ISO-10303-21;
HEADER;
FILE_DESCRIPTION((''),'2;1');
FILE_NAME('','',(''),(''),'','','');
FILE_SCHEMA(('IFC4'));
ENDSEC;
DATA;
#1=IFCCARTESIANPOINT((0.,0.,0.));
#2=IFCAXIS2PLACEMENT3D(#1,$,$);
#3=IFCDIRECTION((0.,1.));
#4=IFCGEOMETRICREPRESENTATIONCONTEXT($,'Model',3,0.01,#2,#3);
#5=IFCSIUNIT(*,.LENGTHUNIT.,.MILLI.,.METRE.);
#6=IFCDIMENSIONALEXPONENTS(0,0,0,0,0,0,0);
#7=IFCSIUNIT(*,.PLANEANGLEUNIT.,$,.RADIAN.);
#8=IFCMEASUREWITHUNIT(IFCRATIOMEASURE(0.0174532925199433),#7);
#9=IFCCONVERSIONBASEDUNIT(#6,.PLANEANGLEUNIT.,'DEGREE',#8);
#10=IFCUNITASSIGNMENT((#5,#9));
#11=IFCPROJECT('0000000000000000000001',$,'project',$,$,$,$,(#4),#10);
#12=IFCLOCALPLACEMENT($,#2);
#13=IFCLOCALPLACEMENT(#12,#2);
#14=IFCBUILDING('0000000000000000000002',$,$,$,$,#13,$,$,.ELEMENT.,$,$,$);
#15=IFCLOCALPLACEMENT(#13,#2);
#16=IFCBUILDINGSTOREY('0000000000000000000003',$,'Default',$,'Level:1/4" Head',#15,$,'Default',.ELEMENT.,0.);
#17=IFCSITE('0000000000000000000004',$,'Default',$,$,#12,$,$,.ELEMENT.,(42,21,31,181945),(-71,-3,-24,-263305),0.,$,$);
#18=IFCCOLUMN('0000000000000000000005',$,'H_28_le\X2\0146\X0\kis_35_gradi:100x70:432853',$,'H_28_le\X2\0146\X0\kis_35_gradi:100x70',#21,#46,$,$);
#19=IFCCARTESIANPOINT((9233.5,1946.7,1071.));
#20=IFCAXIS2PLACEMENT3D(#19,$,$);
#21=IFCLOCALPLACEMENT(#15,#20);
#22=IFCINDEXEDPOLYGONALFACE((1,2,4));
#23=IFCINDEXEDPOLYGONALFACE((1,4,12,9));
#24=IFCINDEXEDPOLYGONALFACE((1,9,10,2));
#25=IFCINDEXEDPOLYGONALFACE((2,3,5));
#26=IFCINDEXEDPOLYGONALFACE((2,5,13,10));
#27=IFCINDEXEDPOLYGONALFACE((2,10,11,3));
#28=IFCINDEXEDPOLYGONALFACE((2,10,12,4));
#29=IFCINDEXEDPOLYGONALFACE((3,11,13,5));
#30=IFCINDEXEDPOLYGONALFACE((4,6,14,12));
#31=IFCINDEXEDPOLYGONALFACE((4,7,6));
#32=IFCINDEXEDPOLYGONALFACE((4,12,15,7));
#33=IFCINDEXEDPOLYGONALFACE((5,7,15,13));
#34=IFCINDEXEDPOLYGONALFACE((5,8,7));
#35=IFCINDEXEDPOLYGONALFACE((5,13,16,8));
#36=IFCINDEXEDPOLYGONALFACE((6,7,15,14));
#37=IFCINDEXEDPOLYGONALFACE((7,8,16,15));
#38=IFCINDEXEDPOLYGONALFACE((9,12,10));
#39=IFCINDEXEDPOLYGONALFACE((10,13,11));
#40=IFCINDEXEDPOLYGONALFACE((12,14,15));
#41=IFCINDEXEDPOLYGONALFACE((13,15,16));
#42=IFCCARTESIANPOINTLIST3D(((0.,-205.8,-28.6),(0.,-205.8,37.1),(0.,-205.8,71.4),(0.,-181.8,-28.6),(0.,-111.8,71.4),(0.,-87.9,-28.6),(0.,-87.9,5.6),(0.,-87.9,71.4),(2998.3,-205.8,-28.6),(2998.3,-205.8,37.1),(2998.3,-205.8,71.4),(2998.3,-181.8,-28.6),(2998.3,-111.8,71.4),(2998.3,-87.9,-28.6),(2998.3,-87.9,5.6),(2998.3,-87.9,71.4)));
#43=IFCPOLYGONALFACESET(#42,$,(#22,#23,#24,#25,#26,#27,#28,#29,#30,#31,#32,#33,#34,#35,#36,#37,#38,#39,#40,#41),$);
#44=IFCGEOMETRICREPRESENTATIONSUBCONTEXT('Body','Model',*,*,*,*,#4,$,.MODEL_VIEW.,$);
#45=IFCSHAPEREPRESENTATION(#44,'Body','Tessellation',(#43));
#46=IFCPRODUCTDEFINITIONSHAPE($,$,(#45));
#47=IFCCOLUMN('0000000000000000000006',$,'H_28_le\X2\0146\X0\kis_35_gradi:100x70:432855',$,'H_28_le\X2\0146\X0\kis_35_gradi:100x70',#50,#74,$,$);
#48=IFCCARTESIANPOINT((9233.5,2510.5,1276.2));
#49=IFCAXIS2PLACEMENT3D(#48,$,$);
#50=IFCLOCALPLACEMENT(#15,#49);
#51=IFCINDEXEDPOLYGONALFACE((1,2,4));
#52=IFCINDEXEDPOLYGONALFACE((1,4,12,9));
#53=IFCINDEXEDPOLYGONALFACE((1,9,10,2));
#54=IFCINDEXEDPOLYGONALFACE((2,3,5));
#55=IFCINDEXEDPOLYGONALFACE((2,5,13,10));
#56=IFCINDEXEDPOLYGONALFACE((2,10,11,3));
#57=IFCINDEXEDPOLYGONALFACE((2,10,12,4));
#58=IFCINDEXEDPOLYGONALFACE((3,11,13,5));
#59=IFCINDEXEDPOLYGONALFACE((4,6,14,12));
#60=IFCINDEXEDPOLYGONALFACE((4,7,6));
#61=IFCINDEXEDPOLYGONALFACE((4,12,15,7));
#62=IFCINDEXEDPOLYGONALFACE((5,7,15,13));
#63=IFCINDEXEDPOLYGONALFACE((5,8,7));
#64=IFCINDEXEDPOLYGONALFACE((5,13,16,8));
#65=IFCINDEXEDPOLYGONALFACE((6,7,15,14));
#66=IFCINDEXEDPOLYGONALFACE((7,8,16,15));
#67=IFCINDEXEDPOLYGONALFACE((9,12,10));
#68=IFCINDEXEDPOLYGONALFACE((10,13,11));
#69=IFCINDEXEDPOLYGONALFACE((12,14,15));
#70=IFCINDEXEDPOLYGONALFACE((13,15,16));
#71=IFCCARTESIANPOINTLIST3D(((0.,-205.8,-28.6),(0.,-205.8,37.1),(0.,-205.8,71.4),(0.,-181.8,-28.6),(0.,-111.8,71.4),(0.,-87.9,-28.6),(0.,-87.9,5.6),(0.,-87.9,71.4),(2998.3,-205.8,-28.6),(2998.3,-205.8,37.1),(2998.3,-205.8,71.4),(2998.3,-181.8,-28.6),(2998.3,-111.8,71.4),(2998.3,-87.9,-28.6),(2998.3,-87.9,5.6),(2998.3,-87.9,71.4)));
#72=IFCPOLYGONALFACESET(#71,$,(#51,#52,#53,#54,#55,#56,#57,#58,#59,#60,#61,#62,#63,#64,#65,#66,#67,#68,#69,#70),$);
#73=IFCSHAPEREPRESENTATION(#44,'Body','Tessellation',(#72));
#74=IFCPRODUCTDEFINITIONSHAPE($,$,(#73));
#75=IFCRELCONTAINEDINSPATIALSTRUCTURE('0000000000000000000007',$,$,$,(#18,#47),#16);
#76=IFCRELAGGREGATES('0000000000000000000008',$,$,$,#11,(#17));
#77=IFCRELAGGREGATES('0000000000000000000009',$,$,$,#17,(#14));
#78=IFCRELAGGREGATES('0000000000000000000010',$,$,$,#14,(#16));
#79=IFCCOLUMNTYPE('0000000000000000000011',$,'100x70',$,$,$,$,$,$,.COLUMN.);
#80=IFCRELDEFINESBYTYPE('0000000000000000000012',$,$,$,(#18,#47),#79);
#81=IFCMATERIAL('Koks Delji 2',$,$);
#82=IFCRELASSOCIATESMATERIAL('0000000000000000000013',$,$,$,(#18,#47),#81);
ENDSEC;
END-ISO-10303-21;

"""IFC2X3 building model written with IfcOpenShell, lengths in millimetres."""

from ifc_helpers import new_model, entity, si_unit, converted_unit, direction, frame, frame_2d, origin, place, context, subcontext, project, spatial, rectangle, extrude, boolean, source, transform, mapped, material, type_object, type_shapes, element, save


model = new_model("IFC2X3")

# Units and contexts
model_context = context("Model", 3, precision=0.01, world=origin(), true_north=direction((0.0, 1.0)))
body_context = subcontext(model_context, "Body", "Model", "MODEL_VIEW")
ifc_project = project(units=[si_unit("LENGTHUNIT", "METRE", prefix="MILLI"), converted_unit("PLANEANGLEUNIT", "DEGREE", entity("IfcRatioMeasure", 0.0174532925199433), si_unit("PLANEANGLEUNIT", "RADIAN"), dimensions=[0, 0, 0, 0, 0, 0, 0])], contexts=[model_context])

# Site, building, storey
site_placement = place(None, origin())
site = spatial("IfcSite", under=ifc_project, at=site_placement, Name="Default", CompositionType="ELEMENT", RefLatitude=(42, 21, 31, 181945), RefLongitude=(-71, -3, -24, -263305), RefElevation=0.0)
building_placement = place(site_placement, origin())
building = spatial("IfcBuilding", under=site, at=building_placement, CompositionType="ELEMENT")
storey_placement = place(building_placement, origin())
storey = spatial("IfcBuildingStorey", under=building, at=storey_placement, Name="Default", ObjectType="Level:1/4\" Head", LongName="Default", CompositionType="ELEMENT", Elevation=0.0)

# Columns
ifc_material_1 = material(Name="Koks Delji 2")
column_type = type_object("IfcColumnType", Name="100x70", PredefinedType="COLUMN")
shared_shape_1 = source(origin(), body_context, "Body", "CSG", [
    boolean("DIFFERENCE", extrude(rectangle(XDim=2998.3, YDim=117.9, at=frame_2d((0.0, 0.0), x_axis=(1.0, 0.0))), frame((1499.1, -146.8, -28.6)), (0.0, 0.0, 1.0), 100.0), extrude(rectangle(XDim=70.0, YDim=100.0, at=frame_2d((0.0, 0.0), x_axis=(0.0, 1.0))), frame((0.0, -146.8, 21.4), z_axis=(-1.0, 0.0, 0.0), x_axis=(0.0, -0.939693, -0.34202)), (0.0, 0.0, -1.0), 2998.3)),
])
type_shapes(column_type, [shared_shape_1])
for number, where, name in (
    (1, (9233.5, 1946.7, 1071.0), "H_28_leņkis_35_gradi:100x70:432853"),
    (2, (9233.5, 2510.5, 1276.2), "H_28_leņkis_35_gradi:100x70:432855"),
):
    element("IfcColumn", number, at=place(storey_placement, frame(where)), inside=storey, type_object=column_type, material=ifc_material_1, Name=name, ObjectType="H_28_leņkis_35_gradi:100x70", context=body_context, shape_type="MappedRepresentation", body=[
        mapped(shared_shape_1, transform((0.0, 0.0, 0.0), scale=1.0)),
    ])

save(model, "model.ifc")
